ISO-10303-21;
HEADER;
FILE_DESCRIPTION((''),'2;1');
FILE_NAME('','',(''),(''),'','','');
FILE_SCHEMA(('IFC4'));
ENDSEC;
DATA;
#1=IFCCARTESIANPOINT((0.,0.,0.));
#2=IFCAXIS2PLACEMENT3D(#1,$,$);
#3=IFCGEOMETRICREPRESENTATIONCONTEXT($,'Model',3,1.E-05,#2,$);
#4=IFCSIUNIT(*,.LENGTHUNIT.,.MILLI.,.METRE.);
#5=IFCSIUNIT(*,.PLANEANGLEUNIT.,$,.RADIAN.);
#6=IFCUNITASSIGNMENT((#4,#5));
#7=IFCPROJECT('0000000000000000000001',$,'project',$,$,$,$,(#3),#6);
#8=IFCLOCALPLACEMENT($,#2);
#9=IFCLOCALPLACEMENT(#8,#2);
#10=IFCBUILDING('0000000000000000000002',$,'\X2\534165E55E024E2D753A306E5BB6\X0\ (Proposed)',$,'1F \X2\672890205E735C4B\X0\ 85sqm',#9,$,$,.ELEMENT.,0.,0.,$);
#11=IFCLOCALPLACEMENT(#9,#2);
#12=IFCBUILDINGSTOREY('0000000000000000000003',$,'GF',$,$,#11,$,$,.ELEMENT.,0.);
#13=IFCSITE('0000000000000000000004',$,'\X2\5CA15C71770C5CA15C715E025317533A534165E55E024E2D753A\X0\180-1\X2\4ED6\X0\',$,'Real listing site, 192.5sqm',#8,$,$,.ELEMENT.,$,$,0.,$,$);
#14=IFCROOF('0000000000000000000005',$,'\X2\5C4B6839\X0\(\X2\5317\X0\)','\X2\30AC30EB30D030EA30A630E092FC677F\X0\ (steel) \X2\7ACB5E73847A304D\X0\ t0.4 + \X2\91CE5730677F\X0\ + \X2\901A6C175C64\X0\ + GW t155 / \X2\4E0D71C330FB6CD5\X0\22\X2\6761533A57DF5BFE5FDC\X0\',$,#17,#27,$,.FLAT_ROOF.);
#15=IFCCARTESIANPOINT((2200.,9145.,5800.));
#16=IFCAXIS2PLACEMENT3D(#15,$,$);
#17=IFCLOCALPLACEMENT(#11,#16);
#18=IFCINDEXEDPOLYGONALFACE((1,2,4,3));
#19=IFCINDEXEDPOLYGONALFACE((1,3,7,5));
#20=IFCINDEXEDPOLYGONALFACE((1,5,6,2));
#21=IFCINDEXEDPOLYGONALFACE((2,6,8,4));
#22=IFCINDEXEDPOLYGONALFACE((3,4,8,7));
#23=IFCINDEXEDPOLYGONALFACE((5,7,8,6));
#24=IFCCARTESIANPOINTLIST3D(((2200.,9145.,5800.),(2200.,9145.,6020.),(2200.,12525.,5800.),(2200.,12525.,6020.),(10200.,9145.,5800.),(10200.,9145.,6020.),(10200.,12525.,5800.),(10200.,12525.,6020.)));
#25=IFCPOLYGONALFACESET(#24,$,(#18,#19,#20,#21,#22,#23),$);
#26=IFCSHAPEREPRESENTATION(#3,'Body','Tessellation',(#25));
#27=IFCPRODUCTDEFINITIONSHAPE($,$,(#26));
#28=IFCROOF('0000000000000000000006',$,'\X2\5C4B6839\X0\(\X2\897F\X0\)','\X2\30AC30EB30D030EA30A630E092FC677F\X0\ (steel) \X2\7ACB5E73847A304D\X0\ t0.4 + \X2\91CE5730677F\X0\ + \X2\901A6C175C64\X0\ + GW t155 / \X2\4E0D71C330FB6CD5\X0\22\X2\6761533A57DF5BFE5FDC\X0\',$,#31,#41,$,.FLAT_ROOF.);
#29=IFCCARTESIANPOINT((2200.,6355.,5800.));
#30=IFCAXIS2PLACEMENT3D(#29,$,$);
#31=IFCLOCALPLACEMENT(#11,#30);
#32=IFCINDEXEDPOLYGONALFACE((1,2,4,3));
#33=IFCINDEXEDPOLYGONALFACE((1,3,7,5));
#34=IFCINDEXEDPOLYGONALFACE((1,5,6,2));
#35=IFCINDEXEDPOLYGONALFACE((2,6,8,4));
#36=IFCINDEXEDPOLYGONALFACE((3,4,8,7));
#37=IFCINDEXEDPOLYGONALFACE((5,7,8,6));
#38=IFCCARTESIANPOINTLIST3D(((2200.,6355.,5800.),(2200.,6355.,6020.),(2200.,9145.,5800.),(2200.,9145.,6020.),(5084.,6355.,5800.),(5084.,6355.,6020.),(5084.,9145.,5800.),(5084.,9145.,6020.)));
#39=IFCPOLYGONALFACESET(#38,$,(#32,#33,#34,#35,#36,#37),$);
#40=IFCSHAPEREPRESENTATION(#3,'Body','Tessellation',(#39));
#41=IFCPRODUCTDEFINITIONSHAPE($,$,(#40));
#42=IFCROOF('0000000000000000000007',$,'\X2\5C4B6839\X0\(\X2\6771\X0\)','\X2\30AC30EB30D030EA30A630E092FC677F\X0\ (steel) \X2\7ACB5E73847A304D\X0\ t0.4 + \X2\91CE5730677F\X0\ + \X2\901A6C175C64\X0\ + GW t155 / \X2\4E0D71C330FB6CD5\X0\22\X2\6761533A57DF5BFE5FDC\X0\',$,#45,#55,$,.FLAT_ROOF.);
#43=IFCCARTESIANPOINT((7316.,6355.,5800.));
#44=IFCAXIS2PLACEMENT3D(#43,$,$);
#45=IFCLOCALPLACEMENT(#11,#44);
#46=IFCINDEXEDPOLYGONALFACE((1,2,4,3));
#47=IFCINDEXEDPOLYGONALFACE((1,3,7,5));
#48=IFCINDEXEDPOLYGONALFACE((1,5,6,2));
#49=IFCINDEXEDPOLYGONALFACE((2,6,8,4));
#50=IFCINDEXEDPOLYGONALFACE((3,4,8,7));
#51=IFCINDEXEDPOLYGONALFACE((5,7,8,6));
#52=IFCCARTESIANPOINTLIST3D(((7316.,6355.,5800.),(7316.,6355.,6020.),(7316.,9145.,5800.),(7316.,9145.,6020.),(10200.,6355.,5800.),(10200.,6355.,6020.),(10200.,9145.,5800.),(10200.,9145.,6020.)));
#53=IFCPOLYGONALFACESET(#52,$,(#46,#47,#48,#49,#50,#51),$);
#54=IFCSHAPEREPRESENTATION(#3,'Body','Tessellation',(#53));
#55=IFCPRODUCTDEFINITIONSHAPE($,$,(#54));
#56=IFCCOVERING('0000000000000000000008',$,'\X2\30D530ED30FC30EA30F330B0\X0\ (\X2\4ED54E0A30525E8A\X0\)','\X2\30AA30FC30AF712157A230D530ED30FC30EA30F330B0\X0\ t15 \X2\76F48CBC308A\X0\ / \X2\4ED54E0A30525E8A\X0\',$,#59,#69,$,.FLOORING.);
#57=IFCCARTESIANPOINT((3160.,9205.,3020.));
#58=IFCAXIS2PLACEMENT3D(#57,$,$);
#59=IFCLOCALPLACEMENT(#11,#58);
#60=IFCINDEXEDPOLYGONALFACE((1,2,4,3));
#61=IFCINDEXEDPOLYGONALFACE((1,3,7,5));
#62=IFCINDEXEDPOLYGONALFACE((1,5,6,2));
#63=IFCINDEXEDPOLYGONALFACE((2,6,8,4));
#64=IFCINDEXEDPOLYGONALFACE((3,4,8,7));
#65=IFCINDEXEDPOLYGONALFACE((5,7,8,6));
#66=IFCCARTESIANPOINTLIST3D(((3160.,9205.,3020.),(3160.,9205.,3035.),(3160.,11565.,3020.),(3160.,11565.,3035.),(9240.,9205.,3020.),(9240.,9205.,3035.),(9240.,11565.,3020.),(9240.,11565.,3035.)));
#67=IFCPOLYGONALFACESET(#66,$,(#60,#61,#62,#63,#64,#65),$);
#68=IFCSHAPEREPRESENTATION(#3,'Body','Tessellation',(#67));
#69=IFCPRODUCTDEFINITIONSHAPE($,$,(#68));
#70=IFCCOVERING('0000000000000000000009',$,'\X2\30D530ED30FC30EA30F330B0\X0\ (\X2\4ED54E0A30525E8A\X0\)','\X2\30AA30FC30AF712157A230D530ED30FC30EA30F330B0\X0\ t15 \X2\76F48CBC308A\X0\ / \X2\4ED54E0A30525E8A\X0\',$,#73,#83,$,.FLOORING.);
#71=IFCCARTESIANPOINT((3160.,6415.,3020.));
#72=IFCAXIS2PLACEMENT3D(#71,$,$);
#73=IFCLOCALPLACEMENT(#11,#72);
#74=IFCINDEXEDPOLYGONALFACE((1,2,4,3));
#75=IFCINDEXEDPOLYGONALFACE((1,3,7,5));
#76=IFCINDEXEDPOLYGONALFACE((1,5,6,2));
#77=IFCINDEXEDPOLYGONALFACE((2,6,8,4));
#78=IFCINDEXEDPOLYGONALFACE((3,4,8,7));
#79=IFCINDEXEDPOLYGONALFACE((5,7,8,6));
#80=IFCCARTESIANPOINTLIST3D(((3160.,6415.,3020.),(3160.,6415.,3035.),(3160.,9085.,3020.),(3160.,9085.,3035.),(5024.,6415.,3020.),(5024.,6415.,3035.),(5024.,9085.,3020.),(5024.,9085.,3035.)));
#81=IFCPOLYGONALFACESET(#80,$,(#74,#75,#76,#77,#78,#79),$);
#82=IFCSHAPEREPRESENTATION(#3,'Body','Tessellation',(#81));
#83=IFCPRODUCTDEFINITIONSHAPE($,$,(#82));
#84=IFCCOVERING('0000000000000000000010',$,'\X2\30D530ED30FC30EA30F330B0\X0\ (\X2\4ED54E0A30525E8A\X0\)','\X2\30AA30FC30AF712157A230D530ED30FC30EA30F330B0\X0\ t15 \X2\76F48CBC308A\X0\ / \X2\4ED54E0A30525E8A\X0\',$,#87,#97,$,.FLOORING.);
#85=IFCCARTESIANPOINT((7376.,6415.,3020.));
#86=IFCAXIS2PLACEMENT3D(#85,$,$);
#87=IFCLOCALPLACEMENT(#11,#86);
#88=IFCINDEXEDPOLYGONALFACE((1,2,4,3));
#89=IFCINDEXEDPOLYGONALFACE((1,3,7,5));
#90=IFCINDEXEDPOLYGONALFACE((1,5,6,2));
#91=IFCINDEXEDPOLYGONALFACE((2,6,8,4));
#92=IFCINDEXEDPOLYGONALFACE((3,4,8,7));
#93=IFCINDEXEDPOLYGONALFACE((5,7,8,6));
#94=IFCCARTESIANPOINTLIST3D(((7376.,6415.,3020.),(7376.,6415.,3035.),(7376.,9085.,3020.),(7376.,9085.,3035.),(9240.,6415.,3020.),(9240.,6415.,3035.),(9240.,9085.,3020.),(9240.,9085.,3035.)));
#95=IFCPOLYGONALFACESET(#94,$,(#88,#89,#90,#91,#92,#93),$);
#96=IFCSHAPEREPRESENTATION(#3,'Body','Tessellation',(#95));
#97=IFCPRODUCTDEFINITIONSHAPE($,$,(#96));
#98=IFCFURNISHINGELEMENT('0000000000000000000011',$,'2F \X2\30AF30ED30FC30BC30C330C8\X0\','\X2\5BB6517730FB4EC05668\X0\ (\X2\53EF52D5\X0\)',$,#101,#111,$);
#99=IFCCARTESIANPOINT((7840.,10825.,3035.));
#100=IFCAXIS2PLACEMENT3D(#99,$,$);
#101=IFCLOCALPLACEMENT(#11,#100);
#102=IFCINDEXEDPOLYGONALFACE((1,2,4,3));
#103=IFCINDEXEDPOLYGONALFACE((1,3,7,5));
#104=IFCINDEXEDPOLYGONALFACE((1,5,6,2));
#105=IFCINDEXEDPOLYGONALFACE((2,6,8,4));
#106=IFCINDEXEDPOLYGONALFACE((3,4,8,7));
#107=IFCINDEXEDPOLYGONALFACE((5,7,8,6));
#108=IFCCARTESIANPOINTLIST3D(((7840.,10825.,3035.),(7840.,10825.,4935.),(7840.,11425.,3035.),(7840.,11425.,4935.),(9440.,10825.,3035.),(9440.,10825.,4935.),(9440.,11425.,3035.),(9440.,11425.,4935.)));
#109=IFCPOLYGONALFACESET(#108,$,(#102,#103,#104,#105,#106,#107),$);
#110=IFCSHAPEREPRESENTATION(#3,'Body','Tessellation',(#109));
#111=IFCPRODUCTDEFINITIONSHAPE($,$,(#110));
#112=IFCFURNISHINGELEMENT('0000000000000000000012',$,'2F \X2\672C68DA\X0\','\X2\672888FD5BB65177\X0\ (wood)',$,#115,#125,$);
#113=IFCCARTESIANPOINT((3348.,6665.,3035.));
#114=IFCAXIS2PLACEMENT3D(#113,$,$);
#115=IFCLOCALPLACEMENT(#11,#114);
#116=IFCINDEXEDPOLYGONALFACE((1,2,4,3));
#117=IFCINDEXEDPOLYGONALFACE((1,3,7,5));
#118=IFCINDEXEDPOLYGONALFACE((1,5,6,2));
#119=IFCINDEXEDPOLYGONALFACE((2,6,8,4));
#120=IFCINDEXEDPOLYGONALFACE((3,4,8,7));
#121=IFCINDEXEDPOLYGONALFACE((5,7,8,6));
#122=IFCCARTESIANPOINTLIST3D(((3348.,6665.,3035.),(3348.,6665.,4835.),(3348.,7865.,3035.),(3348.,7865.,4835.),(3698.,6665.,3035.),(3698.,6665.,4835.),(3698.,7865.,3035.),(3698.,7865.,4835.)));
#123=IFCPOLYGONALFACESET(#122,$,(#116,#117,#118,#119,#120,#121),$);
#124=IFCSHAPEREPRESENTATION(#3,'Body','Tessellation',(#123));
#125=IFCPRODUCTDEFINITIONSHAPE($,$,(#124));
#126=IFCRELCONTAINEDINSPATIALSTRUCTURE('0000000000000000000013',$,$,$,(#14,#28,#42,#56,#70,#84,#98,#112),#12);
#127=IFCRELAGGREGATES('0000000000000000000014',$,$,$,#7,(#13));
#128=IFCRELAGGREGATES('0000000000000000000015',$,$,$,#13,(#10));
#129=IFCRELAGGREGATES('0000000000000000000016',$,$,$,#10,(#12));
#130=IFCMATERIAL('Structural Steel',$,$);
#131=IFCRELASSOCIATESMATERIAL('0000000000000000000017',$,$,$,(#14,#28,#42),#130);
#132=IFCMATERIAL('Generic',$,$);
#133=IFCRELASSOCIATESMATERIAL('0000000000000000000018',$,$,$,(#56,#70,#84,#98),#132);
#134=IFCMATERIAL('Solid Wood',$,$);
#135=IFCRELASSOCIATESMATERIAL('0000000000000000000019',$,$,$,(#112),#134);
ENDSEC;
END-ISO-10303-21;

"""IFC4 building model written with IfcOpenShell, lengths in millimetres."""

from ifc_helpers import new_model, si_unit, frame, frame_2d, origin, place, context, project, spatial, rectangle, extrude, material, element, save


model = new_model("IFC4")

# Units and contexts
model_context = context("Model", 3, precision=1e-05, world=origin())
ifc_project = project(units=[si_unit("LENGTHUNIT", "METRE", prefix="MILLI"), si_unit("PLANEANGLEUNIT", "RADIAN")], contexts=[model_context])

# Site, building, storey
site_placement = place(None, origin())
site = spatial("IfcSite", under=ifc_project, at=site_placement, Name="岡山県岡山市北区十日市中町180-1他", ObjectType="Real listing site, 192.5sqm", CompositionType="ELEMENT", RefElevation=0.0)
building_placement = place(site_placement, origin())
building = spatial("IfcBuilding", under=site, at=building_placement, Name="十日市中町の家 (Proposed)", ObjectType="1F 木造平屋 85sqm", CompositionType="ELEMENT", ElevationOfRefHeight=0.0, ElevationOfTerrain=0.0)
storey_placement = place(building_placement, origin())
storey = spatial("IfcBuildingStorey", under=building, at=storey_placement, Name="GF", CompositionType="ELEMENT", Elevation=0.0)

# Shared definitions
ifc_material_1 = material(Name="Solid Wood")

# Shared definitions
ifc_material_2 = material(Name="Generic")

# Roofs
ifc_material_3 = material(Name="Structural Steel")
for number, where, name in (
    (1, (2200.0, 9145.0, 5800.0), "屋根(北)"),
):
    element("IfcRoof", number, at=place(storey_placement, frame(where)), inside=storey, material=ifc_material_3, Name=name, Description="ガルバリウム鋼板 (steel) 立平葺き t0.4 + 野地板 + 通気層 + GW t155 / 不燃・法22条区域対応", PredefinedType="FLAT_ROOF", context=model_context, shape_type="SweptSolid", body=[
        extrude(rectangle(XDim=8000.0, YDim=3380.0, at=frame_2d((4000.0, 1690.0))), frame((2200.0, 9145.0, 5800.0)), (0.0, 0.0, 1.0), 220.0),
    ])
roof_1_placement = place(storey_placement, frame((2200.0, 6355.0, 5800.0)))
element("IfcRoof", 2, at=roof_1_placement, inside=storey, material=ifc_material_3, Name="屋根(西)", Description="ガルバリウム鋼板 (steel) 立平葺き t0.4 + 野地板 + 通気層 + GW t155 / 不燃・法22条区域対応", PredefinedType="FLAT_ROOF", context=model_context, shape_type="SweptSolid", body=[
    extrude(rectangle(XDim=2884.0, YDim=2790.0, at=frame_2d((1442.0, 1395.0))), frame((2200.0, 6355.0, 5800.0)), (0.0, 0.0, 1.0), 220.0),
])
roof_2_placement = place(storey_placement, frame((7316.0, 6355.0, 5800.0)))
element("IfcRoof", 3, at=roof_2_placement, inside=storey, material=ifc_material_3, Name="屋根(東)", Description="ガルバリウム鋼板 (steel) 立平葺き t0.4 + 野地板 + 通気層 + GW t155 / 不燃・法22条区域対応", PredefinedType="FLAT_ROOF", context=model_context, shape_type="SweptSolid", body=[
    extrude(rectangle(XDim=2884.0, YDim=2790.0, at=frame_2d((1442.0, 1395.0))), frame((7316.0, 6355.0, 5800.0)), (0.0, 0.0, 1.0), 220.0),
])

# Coverings
covering_1_placement = place(storey_placement, frame((3160.0, 9205.0, 3020.0)))
element("IfcCovering", 4, at=covering_1_placement, inside=storey, material=ifc_material_2, Name="フローリング (仕上げ床)", Description="オーク無垢フローリング t15 直貼り / 仕上げ床", PredefinedType="FLOORING", context=model_context, shape_type="SweptSolid", body=[
    extrude(rectangle(XDim=6080.0, YDim=2360.0, at=frame_2d((3040.0, 1180.0))), frame((3160.0, 9205.0, 3020.0)), (0.0, 0.0, 1.0), 15.0),
])
covering_2_placement = place(storey_placement, frame((3160.0, 6415.0, 3020.0)))
element("IfcCovering", 5, at=covering_2_placement, inside=storey, material=ifc_material_2, Name="フローリング (仕上げ床)", Description="オーク無垢フローリング t15 直貼り / 仕上げ床", PredefinedType="FLOORING", context=model_context, shape_type="SweptSolid", body=[
    extrude(rectangle(XDim=1864.0, YDim=2670.0, at=frame_2d((932.0, 1335.0))), frame((3160.0, 6415.0, 3020.0)), (0.0, 0.0, 1.0), 15.0),
])
covering_3_placement = place(storey_placement, frame((7376.0, 6415.0, 3020.0)))
element("IfcCovering", 6, at=covering_3_placement, inside=storey, material=ifc_material_2, Name="フローリング (仕上げ床)", Description="オーク無垢フローリング t15 直貼り / 仕上げ床", PredefinedType="FLOORING", context=model_context, shape_type="SweptSolid", body=[
    extrude(rectangle(XDim=1864.0, YDim=2670.0, at=frame_2d((932.0, 1335.0))), frame((7376.0, 6415.0, 3020.0)), (0.0, 0.0, 1.0), 15.0),
])

# Furnishing elements
furnishing_1_placement = place(storey_placement, frame((7840.0, 10825.0, 3035.0)))
element("IfcFurnishingElement", 7, at=furnishing_1_placement, inside=storey, material=ifc_material_2, Name="2F クローゼット", Description="家具・什器 (可動)", context=model_context, shape_type="SweptSolid", body=[
    extrude(rectangle(XDim=1600.0, YDim=600.0, at=frame_2d((800.0, 300.0))), frame((7840.0, 10825.0, 3035.0)), (0.0, 0.0, 1.0), 1900.0),
])
furnishing_2_placement = place(storey_placement, frame((3348.0, 6665.0, 3035.0)))
element("IfcFurnishingElement", 8, at=furnishing_2_placement, inside=storey, material=ifc_material_1, Name="2F 本棚", Description="木製家具 (wood)", context=model_context, shape_type="SweptSolid", body=[
    extrude(rectangle(XDim=350.0, YDim=1200.0, at=frame_2d((175.0, 600.0))), frame((3348.0, 6665.0, 3035.0)), (0.0, 0.0, 1.0), 1800.0),
])

save(model, "model.ifc")
